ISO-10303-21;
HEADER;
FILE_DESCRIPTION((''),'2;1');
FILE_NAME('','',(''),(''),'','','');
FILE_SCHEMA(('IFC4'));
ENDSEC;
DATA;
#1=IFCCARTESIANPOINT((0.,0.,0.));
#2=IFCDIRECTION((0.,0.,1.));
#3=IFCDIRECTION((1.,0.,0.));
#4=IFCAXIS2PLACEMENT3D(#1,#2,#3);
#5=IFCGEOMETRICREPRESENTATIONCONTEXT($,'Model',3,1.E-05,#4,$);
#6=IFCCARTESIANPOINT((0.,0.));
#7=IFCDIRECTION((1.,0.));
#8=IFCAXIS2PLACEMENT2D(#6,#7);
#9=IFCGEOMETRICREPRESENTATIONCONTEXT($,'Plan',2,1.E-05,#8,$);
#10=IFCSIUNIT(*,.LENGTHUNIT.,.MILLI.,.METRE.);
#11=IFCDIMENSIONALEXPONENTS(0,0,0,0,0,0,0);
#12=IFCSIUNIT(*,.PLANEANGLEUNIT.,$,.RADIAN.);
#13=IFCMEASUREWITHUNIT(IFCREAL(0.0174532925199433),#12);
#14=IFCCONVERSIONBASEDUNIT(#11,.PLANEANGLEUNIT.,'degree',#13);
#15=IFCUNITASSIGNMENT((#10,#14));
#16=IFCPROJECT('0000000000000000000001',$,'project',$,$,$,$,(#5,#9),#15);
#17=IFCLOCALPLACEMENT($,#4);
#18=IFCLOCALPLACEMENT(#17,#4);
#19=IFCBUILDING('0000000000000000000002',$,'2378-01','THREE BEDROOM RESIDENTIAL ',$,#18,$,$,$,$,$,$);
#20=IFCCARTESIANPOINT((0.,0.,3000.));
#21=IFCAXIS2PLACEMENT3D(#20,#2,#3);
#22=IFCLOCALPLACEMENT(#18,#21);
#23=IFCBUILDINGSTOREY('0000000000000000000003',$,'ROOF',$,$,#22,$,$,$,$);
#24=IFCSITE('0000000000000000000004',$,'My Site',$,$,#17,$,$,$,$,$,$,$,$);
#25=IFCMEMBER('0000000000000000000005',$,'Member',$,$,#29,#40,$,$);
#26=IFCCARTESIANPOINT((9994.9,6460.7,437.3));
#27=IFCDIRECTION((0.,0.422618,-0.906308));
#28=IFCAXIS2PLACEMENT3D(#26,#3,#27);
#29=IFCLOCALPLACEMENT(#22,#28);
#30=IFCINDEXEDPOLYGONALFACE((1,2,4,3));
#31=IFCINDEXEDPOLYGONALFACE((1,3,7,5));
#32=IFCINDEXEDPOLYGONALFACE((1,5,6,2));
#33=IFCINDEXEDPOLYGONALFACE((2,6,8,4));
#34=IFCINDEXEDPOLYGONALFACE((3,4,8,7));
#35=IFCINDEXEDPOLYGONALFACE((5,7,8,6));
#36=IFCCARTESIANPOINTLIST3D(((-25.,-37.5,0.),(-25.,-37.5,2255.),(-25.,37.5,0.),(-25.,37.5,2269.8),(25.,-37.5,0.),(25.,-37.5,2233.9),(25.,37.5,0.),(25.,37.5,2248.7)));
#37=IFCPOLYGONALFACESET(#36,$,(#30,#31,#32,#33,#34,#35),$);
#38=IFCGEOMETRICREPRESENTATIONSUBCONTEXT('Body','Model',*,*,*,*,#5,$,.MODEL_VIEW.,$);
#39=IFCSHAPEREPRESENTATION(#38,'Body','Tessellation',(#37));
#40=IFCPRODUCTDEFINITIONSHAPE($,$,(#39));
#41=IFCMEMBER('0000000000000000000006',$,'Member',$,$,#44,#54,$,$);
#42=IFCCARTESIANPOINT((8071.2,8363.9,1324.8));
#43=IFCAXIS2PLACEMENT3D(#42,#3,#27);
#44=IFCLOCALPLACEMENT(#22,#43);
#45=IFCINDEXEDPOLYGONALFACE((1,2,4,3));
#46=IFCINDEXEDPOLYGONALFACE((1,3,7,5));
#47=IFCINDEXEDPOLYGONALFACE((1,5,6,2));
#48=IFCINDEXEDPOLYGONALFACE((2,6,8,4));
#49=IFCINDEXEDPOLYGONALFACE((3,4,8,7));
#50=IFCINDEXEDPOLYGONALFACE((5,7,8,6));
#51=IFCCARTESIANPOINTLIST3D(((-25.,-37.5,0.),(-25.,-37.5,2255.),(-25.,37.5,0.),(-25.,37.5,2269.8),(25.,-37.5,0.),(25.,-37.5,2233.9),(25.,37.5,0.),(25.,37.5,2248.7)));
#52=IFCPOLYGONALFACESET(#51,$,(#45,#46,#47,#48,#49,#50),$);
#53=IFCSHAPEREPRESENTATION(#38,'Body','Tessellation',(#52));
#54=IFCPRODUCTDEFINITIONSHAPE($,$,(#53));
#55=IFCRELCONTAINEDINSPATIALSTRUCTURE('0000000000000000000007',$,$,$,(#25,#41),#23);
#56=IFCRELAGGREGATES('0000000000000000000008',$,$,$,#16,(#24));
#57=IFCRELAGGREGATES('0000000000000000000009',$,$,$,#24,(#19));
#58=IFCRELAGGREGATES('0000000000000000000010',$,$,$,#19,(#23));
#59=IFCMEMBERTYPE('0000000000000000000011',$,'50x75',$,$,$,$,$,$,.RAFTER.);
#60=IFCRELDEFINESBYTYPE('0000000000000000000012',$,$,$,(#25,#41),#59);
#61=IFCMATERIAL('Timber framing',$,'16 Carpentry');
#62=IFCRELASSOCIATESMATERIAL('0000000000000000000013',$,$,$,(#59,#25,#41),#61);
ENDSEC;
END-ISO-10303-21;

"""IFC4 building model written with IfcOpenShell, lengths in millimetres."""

from ifc_helpers import new_model, entity, si_unit, converted_unit, frame, origin_with_axes, origin_2d_with_axis, place, context, subcontext, project, spatial, rectangle, extrude, clip, halfspace, material, material_profile, profile_set, profile_usage, type_object, element, save


model = new_model("IFC4")

# Units and contexts
model_context = context("Model", 3, precision=1e-05, world=origin_with_axes())
plan_context = context("Plan", 2, precision=1e-05, world=origin_2d_with_axis())
body_context = subcontext(model_context, "Body", "Model", "MODEL_VIEW")
ifc_project = project(units=[si_unit("LENGTHUNIT", "METRE", prefix="MILLI"), converted_unit("PLANEANGLEUNIT", "degree", entity("IfcReal", 0.0174532925199433), si_unit("PLANEANGLEUNIT", "RADIAN"), dimensions=[0, 0, 0, 0, 0, 0, 0])], contexts=[model_context, plan_context])

# Site, building, storey
site_placement = place(None, origin_with_axes())
site = spatial("IfcSite", under=ifc_project, at=site_placement, Name="My Site")
building_placement = place(site_placement, origin_with_axes())
building = spatial("IfcBuilding", under=site, at=building_placement, Name="2378-01", Description="THREE BEDROOM RESIDENTIAL ")
storey_placement = place(building_placement, frame((0.0, 0.0, 3000.0), z_axis=(0.0, 0.0, 1.0), x_axis=(1.0, 0.0, 0.0)))
storey = spatial("IfcBuildingStorey", under=building, at=storey_placement, Name="ROOF")

# Members
ifc_material_1 = material(Name="Timber framing", Category="16 Carpentry")
ifc_material_profile_1 = material_profile(ifc_material_1, rectangle(XDim=50.0, YDim=75.0), Name="Lumber2", Category="Substrate", Priority=2)
ifc_profile_set_1 = profile_set([ifc_material_profile_1])
member_type_1 = type_object("IfcMemberType", Name="50x75", PredefinedType="RAFTER", material=ifc_profile_set_1)
ifc_profile_usage_1 = profile_usage(ifc_profile_set_1, cardinal=5)
member_1_placement = place(storey_placement, frame((9994.9, 6460.7, 437.3), z_axis=(1.0, 0.0, 0.0), x_axis=(0.0, 0.422618, -0.906308)))
element("IfcMember", 1, at=member_1_placement, inside=storey, type_object=member_type_1, material=ifc_profile_usage_1, Name="Member", context=body_context, shape_type="Clipping", body=[
    clip(extrude(rectangle(XDim=50.0, YDim=75.0), origin_with_axes(), (0.0, 0.0, 1.0), 2326.8), halfspace(frame((-15.0, -69.7, 2244.4), z_axis=(0.383022, -0.178606, 0.906308), x_axis=(-0.422618, -0.906308, 0.0)), False)),
])
ifc_profile_usage_2 = profile_usage(ifc_profile_set_1, cardinal=5)
member_2_placement = place(storey_placement, frame((8071.2, 8363.9, 1324.8), z_axis=(1.0, 0.0, 0.0), x_axis=(0.0, 0.422618, -0.906308)))
element("IfcMember", 2, at=member_2_placement, inside=storey, type_object=member_type_1, material=ifc_profile_usage_2, Name="Member", context=body_context, shape_type="Clipping", body=[
    clip(extrude(rectangle(XDim=50.0, YDim=75.0), origin_with_axes(), (0.0, 0.0, 1.0), 2326.8), halfspace(frame((-15.0, -69.7, 2244.4), z_axis=(0.383022, -0.178606, 0.906308), x_axis=(-0.422618, -0.906308, 0.0)), False)),
])

save(model, "model.ifc")
